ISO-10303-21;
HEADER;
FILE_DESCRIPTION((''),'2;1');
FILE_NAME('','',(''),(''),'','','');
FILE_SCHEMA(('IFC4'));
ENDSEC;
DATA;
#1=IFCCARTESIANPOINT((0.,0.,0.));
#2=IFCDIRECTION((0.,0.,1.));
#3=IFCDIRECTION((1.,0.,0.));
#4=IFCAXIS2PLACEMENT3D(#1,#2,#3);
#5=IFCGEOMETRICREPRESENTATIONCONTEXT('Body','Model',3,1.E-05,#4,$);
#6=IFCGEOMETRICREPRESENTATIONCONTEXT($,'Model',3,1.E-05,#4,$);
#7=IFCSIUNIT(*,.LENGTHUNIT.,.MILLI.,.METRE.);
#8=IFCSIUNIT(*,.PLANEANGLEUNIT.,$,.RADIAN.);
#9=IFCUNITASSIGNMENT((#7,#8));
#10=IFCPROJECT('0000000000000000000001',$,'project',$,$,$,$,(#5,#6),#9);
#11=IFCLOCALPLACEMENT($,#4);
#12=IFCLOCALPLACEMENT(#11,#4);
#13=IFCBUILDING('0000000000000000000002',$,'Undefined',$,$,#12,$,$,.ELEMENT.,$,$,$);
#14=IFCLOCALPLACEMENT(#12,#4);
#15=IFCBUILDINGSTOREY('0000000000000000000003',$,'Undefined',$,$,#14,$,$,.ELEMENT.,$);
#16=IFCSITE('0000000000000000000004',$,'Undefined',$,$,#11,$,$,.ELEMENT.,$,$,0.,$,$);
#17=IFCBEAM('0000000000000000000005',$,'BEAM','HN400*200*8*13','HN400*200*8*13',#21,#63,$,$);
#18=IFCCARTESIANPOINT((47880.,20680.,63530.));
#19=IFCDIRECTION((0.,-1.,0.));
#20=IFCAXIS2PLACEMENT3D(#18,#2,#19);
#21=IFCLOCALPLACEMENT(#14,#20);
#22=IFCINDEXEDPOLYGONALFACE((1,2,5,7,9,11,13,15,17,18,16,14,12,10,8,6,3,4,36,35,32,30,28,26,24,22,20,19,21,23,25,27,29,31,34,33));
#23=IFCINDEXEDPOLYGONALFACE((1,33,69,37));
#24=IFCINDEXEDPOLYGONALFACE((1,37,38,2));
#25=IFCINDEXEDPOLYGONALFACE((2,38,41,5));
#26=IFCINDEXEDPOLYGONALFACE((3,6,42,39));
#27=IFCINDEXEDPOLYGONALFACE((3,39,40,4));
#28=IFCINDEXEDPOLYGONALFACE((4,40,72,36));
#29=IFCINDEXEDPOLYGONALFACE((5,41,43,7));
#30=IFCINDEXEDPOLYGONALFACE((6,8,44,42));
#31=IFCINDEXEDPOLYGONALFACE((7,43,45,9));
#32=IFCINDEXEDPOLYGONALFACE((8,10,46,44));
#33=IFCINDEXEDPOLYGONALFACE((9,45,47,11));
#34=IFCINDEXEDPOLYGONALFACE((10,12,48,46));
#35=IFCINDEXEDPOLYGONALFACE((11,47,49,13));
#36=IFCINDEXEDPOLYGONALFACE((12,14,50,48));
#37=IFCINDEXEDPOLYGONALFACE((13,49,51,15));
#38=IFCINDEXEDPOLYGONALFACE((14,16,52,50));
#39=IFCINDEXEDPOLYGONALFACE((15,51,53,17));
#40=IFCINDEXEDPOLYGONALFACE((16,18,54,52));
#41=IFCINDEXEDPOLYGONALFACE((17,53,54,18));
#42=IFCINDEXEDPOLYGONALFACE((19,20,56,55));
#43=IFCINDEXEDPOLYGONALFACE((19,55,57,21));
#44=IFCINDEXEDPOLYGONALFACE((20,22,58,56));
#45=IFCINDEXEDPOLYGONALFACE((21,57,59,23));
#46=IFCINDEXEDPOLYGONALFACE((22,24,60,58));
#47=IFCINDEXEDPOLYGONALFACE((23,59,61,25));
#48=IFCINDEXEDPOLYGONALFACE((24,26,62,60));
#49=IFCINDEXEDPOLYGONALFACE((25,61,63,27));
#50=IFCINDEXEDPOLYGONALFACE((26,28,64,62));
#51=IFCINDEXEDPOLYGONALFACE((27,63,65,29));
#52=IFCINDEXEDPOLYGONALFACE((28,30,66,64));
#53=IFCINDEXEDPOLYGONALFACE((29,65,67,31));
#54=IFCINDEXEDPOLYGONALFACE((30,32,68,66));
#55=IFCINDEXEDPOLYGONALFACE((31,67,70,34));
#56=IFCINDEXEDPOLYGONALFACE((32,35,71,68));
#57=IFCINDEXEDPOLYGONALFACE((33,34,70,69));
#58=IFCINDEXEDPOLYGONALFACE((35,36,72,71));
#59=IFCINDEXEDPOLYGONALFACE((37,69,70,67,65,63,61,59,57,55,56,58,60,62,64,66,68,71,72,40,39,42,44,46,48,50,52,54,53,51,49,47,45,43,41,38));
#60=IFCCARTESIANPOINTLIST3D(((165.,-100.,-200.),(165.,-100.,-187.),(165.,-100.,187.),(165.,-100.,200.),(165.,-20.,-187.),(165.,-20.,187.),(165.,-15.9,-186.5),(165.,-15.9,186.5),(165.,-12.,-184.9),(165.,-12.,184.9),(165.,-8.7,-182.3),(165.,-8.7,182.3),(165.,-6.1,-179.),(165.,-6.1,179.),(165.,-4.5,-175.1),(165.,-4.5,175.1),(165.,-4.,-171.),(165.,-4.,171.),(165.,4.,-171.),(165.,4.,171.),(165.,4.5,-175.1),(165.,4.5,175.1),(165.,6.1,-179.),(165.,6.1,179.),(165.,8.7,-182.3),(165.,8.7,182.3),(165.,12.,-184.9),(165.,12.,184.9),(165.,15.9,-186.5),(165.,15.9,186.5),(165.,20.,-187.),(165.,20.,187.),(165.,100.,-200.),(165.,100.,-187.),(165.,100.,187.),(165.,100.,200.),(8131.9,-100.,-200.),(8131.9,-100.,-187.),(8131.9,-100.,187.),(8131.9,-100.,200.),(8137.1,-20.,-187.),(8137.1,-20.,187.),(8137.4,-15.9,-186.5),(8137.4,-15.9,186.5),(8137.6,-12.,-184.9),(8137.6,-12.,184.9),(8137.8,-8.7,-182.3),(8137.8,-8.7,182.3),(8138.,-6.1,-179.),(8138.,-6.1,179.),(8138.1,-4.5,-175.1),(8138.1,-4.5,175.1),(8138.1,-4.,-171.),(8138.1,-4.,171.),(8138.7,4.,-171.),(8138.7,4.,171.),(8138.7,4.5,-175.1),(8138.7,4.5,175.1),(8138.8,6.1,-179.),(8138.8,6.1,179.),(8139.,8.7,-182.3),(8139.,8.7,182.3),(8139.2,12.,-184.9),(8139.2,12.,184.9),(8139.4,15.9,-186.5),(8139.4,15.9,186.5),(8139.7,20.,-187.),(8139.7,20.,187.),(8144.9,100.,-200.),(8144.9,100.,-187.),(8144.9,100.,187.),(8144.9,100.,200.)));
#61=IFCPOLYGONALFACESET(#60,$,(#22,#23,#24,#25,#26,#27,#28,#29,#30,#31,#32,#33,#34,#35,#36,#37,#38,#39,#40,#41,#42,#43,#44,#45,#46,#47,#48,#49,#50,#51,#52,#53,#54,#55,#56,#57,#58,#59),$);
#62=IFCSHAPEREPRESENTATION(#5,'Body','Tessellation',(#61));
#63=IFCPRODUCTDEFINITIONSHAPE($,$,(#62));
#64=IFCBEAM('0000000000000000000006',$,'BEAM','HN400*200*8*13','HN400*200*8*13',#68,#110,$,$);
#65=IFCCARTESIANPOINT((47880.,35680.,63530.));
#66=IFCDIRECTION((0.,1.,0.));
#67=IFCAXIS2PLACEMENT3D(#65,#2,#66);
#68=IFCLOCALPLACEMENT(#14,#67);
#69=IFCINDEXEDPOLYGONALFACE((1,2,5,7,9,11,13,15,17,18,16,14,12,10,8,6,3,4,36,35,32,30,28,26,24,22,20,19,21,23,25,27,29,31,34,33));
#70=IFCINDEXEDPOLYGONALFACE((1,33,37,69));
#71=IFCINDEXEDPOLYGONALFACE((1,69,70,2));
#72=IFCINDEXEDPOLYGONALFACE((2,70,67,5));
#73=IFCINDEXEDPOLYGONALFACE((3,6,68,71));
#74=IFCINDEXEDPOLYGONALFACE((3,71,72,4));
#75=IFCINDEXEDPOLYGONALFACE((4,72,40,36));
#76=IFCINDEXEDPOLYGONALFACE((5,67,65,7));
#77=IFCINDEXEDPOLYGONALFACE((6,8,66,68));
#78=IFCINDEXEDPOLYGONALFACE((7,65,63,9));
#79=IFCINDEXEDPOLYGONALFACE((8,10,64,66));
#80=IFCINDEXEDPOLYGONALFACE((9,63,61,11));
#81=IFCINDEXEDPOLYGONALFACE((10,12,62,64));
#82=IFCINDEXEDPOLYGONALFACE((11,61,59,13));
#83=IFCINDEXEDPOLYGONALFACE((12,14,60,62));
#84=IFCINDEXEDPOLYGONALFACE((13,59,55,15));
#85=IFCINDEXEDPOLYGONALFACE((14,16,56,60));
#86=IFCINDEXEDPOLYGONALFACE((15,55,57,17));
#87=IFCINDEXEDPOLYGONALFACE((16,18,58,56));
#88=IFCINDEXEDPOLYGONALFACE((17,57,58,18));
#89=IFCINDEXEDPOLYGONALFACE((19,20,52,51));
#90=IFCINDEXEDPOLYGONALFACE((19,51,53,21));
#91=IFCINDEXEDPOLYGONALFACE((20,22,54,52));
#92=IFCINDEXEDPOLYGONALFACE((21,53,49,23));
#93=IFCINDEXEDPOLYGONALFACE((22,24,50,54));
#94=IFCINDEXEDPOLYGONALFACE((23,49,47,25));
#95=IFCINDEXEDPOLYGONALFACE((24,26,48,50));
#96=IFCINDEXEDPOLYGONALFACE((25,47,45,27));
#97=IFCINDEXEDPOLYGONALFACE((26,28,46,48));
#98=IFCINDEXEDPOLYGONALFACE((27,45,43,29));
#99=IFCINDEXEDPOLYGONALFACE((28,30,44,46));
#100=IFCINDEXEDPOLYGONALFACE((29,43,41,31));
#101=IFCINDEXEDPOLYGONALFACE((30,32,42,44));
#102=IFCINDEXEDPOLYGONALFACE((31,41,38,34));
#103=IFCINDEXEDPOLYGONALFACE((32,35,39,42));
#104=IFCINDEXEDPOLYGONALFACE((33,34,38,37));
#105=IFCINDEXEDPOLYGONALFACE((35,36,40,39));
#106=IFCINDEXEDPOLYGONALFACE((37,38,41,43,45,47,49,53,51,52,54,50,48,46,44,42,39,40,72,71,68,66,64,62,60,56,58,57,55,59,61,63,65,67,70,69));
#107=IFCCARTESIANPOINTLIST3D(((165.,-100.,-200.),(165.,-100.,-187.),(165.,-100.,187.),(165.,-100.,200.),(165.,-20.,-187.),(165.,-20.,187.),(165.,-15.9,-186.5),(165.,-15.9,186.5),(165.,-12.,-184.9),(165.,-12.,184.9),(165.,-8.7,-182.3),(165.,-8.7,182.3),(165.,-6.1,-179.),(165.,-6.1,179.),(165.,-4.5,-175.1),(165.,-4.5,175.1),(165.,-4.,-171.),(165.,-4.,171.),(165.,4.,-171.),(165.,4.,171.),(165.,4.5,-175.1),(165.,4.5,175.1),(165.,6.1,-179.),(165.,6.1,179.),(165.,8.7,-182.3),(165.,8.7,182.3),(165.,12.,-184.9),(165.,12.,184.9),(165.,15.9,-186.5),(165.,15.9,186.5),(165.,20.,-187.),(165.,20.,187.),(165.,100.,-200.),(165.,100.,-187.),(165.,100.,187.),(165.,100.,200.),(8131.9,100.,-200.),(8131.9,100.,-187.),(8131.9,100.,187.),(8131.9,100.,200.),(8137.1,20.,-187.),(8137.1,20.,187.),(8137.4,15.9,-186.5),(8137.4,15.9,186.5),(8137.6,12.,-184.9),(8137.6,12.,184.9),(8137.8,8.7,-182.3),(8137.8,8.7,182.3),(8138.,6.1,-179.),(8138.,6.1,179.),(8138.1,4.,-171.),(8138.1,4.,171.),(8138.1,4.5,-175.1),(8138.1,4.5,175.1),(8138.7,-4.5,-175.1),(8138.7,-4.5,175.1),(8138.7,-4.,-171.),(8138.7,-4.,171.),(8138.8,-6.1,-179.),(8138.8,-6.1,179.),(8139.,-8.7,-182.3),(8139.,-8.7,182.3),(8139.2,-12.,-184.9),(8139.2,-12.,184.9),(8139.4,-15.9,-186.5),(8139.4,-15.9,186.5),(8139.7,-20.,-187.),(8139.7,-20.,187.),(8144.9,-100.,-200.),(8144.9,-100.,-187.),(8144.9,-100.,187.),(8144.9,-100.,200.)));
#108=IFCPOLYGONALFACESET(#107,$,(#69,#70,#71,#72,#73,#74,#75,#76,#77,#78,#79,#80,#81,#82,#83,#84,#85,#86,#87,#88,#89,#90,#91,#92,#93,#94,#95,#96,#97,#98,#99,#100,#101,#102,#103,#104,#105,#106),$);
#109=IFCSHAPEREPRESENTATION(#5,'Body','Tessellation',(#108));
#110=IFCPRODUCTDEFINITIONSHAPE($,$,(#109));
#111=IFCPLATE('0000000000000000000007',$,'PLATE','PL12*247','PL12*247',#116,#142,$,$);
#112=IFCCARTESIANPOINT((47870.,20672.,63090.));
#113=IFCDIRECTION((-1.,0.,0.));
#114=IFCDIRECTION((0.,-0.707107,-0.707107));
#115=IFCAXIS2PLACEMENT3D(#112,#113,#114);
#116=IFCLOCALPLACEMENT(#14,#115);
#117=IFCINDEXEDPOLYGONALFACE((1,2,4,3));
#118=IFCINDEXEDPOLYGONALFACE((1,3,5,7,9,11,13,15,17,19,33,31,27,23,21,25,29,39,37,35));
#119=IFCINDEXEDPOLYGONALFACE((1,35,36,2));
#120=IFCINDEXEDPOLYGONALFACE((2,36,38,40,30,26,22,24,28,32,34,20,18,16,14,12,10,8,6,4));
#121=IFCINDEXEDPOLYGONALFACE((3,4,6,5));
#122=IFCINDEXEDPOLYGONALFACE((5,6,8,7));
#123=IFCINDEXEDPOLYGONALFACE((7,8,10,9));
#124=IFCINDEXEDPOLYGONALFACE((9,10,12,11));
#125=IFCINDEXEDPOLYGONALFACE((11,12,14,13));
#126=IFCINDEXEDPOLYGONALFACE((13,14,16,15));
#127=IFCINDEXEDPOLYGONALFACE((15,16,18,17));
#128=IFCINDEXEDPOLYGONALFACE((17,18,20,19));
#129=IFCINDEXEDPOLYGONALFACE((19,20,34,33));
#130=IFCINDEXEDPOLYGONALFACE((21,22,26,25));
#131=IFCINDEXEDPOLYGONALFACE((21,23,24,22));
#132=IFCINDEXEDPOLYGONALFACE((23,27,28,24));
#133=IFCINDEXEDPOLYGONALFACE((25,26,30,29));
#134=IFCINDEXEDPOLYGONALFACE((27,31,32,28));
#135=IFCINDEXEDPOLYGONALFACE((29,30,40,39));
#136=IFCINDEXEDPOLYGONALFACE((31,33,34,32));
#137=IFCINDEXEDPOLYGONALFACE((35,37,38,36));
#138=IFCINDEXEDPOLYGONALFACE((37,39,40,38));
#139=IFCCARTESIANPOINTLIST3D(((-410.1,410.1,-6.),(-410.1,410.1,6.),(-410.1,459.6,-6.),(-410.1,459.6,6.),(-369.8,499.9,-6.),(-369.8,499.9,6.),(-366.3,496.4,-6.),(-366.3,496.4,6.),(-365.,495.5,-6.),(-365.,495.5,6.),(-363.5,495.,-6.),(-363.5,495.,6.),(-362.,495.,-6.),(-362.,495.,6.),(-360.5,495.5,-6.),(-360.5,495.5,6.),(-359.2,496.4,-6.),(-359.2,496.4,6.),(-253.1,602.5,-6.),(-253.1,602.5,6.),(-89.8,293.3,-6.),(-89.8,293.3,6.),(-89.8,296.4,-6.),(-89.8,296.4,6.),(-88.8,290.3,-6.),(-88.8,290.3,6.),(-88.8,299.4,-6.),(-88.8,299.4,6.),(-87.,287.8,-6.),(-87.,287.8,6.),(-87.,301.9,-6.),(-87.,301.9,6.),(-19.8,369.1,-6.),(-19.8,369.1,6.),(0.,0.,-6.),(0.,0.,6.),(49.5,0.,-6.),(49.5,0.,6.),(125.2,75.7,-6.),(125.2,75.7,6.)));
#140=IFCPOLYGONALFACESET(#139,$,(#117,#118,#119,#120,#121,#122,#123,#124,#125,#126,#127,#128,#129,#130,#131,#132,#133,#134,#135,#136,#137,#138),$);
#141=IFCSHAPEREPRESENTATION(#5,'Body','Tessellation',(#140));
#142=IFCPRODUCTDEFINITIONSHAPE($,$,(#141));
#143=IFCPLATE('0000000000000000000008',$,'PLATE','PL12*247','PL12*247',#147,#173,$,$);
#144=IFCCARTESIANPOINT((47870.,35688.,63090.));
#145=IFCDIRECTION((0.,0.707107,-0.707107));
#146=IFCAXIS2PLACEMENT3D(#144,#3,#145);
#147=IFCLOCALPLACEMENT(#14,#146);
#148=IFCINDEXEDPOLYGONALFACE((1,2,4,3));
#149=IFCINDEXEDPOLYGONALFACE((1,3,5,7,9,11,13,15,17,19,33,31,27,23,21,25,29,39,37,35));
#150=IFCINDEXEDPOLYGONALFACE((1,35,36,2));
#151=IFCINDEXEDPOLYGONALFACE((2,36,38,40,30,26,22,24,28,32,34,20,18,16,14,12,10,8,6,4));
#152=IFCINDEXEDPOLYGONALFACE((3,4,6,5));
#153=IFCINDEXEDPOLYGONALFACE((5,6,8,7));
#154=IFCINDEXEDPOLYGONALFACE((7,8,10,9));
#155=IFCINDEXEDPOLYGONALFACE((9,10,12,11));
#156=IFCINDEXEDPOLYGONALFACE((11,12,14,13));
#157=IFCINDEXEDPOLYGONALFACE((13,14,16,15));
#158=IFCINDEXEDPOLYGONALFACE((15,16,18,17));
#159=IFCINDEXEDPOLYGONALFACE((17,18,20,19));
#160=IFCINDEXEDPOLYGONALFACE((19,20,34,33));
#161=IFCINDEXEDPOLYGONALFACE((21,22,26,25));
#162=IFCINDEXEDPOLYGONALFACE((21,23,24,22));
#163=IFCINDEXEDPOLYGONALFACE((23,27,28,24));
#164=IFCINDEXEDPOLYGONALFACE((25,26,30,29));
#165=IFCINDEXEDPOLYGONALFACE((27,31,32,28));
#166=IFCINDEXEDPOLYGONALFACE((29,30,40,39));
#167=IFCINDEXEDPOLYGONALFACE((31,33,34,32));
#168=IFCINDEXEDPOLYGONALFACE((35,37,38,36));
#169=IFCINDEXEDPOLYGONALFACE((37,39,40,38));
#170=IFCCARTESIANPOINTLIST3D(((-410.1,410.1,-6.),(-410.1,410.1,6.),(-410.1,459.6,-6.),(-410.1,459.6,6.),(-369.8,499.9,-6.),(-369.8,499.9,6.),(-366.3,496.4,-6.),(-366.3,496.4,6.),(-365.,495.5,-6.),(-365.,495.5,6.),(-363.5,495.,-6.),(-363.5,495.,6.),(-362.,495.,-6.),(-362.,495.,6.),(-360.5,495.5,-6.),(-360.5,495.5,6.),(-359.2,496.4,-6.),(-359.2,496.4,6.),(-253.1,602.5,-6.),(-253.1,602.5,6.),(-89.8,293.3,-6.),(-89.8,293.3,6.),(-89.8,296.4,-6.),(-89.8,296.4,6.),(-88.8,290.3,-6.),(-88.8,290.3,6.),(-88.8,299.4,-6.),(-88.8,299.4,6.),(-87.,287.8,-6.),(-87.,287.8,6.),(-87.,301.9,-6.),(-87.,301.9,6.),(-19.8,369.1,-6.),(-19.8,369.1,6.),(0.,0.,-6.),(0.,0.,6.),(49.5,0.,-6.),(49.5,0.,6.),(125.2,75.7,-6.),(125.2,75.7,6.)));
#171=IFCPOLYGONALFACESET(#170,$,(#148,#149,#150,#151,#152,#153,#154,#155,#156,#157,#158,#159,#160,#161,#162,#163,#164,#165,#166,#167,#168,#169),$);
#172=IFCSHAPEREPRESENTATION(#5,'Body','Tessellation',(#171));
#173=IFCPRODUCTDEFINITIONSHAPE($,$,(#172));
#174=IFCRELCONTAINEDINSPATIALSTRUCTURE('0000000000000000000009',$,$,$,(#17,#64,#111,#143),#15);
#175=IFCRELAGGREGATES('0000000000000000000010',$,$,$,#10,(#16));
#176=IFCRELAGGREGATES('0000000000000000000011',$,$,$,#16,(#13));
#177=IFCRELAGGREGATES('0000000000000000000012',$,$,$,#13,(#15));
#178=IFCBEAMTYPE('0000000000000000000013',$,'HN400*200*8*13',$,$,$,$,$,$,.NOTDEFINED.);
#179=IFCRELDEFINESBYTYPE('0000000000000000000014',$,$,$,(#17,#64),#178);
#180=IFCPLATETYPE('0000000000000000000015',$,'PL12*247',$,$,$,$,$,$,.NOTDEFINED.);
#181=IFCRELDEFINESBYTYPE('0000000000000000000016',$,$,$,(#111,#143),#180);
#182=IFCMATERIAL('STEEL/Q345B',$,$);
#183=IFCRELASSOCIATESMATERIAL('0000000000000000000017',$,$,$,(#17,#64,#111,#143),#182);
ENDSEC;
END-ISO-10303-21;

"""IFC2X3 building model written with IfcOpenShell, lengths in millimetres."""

from ifc_helpers import new_model, si_unit, frame, origin_with_axes, origin_2d_with_axis, place, context, project, spatial, polyline, i_section, outline, extrude, clip, halfspace, material, type_object, element, save


model = new_model("IFC2X3")

# Units and contexts
model_context_1 = context("Model", 3, precision=1e-05, world=origin_with_axes(), identifier="Body")
model_context_2 = context("Model", 3, precision=1e-05, world=origin_with_axes())
ifc_project = project(units=[si_unit("LENGTHUNIT", "METRE", prefix="MILLI"), si_unit("PLANEANGLEUNIT", "RADIAN")], contexts=[model_context_1, model_context_2])

# Site, building, storey
site_placement = place(None, origin_with_axes())
site = spatial("IfcSite", under=ifc_project, at=site_placement, Name="Undefined", CompositionType="ELEMENT", RefElevation=0.0)
building_placement = place(site_placement, origin_with_axes())
building = spatial("IfcBuilding", under=site, at=building_placement, Name="Undefined", CompositionType="ELEMENT")
storey_placement = place(building_placement, origin_with_axes())
storey = spatial("IfcBuildingStorey", under=building, at=storey_placement, Name="Undefined", CompositionType="ELEMENT")

# Beams
ifc_material_1 = material(Name="STEEL/Q345B")
beam_type_1 = type_object("IfcBeamType", Name="HN400*200*8*13", PredefinedType="NOTDEFINED")
beam_1_placement = place(storey_placement, frame((47880.0, 20680.0, 63530.0), z_axis=(0.0, 0.0, 1.0), x_axis=(0.0, -1.0, 0.0)))
element("IfcBeam", 1, at=beam_1_placement, inside=storey, type_object=beam_type_1, material=ifc_material_1, Name="BEAM", Description="HN400*200*8*13", ObjectType="HN400*200*8*13", context=model_context_1, shape_type="Clipping", body=[
    clip(clip(extrude(i_section(OverallWidth=200.0, OverallDepth=400.0, WebThickness=8.0, FlangeThickness=13.0, FilletRadius=16.0, at=origin_2d_with_axis()), frame((8145.0, 0.0, 0.0), z_axis=(-1.0, 0.0, 0.0), x_axis=(0.0, -1.0, 0.0)), (0.0, 0.0, 1.0), 7980.0), halfspace(frame((8139.3, 13.2, 300.0), z_axis=(0.997873, -0.065183, 0.0), x_axis=(0.065184, 0.997873, 0.0)), False)), halfspace(frame((165.0, -69.2, 200.0), z_axis=(1.0, 0.0, 0.0), x_axis=(0.0, 0.0, 1.0)), True)),
])
beam_2_placement = place(storey_placement, frame((47880.0, 35680.0, 63530.0), z_axis=(0.0, 0.0, 1.0), x_axis=(0.0, 1.0, 0.0)))
element("IfcBeam", 2, at=beam_2_placement, inside=storey, type_object=beam_type_1, material=ifc_material_1, Name="BEAM", Description="HN400*200*8*13", ObjectType="HN400*200*8*13", context=model_context_1, shape_type="Clipping", body=[
    clip(clip(extrude(i_section(OverallWidth=200.0, OverallDepth=400.0, WebThickness=8.0, FlangeThickness=13.0, FilletRadius=16.0, at=origin_2d_with_axis()), frame((8145.0, 0.0, 0.0), z_axis=(-1.0, 0.0, 0.0), x_axis=(0.0, -1.0, 0.0)), (0.0, 0.0, 1.0), 7980.0), halfspace(frame((8139.3, -13.2, 300.0), z_axis=(0.997873, 0.065184, 0.0), x_axis=(0.0, 0.0, -1.0)), False)), halfspace(frame((165.0, 69.2, 200.0), z_axis=(1.0, 0.0, 0.0), x_axis=(0.0, -1.0, 0.0)), True)),
])

# Plates
plate_type_1 = type_object("IfcPlateType", Name="PL12*247", PredefinedType="NOTDEFINED")
for number, where, z_axis, x_axis, name in (
    (3, (47870.0, 20672.0, 63090.0), (-1.0, 0.0, 0.0), (0.0, -0.707107, -0.707107), "PLATE"),
    (4, (47870.0, 35688.0, 63090.0), (1.0, 0.0, 0.0), (0.0, 0.707107, -0.707107), "PLATE"),
):
    element("IfcPlate", number, at=place(storey_placement, frame(where, z_axis=z_axis, x_axis=x_axis)), inside=storey, type_object=plate_type_1, material=ifc_material_1, Name=name, Description="PL12*247", ObjectType="PL12*247", context=model_context_1, shape_type="SweptSolid", body=[
        extrude(outline(polyline([(0.0, 0.0), (49.5, 0.0), (125.2, 75.7), (-87.0, 287.8), (-88.8, 290.3), (-89.8, 293.3), (-89.8, 296.4), (-88.8, 299.4), (-87.0, 301.9), (-19.8, 369.1), (-253.1, 602.5), (-359.2, 496.4), (-360.5, 495.5), (-362.0, 495.0), (-363.5, 495.0), (-365.0, 495.5), (-366.3, 496.4), (-369.8, 499.9), (-410.1, 459.6), (-410.1, 410.1), (0.0, 0.0)])), frame((0.0, 0.0, -6.0), z_axis=(0.0, 0.0, 1.0), x_axis=(1.0, 0.0, 0.0)), (0.0, 0.0, 1.0), 12.0),
    ])

save(model, "model.ifc")
